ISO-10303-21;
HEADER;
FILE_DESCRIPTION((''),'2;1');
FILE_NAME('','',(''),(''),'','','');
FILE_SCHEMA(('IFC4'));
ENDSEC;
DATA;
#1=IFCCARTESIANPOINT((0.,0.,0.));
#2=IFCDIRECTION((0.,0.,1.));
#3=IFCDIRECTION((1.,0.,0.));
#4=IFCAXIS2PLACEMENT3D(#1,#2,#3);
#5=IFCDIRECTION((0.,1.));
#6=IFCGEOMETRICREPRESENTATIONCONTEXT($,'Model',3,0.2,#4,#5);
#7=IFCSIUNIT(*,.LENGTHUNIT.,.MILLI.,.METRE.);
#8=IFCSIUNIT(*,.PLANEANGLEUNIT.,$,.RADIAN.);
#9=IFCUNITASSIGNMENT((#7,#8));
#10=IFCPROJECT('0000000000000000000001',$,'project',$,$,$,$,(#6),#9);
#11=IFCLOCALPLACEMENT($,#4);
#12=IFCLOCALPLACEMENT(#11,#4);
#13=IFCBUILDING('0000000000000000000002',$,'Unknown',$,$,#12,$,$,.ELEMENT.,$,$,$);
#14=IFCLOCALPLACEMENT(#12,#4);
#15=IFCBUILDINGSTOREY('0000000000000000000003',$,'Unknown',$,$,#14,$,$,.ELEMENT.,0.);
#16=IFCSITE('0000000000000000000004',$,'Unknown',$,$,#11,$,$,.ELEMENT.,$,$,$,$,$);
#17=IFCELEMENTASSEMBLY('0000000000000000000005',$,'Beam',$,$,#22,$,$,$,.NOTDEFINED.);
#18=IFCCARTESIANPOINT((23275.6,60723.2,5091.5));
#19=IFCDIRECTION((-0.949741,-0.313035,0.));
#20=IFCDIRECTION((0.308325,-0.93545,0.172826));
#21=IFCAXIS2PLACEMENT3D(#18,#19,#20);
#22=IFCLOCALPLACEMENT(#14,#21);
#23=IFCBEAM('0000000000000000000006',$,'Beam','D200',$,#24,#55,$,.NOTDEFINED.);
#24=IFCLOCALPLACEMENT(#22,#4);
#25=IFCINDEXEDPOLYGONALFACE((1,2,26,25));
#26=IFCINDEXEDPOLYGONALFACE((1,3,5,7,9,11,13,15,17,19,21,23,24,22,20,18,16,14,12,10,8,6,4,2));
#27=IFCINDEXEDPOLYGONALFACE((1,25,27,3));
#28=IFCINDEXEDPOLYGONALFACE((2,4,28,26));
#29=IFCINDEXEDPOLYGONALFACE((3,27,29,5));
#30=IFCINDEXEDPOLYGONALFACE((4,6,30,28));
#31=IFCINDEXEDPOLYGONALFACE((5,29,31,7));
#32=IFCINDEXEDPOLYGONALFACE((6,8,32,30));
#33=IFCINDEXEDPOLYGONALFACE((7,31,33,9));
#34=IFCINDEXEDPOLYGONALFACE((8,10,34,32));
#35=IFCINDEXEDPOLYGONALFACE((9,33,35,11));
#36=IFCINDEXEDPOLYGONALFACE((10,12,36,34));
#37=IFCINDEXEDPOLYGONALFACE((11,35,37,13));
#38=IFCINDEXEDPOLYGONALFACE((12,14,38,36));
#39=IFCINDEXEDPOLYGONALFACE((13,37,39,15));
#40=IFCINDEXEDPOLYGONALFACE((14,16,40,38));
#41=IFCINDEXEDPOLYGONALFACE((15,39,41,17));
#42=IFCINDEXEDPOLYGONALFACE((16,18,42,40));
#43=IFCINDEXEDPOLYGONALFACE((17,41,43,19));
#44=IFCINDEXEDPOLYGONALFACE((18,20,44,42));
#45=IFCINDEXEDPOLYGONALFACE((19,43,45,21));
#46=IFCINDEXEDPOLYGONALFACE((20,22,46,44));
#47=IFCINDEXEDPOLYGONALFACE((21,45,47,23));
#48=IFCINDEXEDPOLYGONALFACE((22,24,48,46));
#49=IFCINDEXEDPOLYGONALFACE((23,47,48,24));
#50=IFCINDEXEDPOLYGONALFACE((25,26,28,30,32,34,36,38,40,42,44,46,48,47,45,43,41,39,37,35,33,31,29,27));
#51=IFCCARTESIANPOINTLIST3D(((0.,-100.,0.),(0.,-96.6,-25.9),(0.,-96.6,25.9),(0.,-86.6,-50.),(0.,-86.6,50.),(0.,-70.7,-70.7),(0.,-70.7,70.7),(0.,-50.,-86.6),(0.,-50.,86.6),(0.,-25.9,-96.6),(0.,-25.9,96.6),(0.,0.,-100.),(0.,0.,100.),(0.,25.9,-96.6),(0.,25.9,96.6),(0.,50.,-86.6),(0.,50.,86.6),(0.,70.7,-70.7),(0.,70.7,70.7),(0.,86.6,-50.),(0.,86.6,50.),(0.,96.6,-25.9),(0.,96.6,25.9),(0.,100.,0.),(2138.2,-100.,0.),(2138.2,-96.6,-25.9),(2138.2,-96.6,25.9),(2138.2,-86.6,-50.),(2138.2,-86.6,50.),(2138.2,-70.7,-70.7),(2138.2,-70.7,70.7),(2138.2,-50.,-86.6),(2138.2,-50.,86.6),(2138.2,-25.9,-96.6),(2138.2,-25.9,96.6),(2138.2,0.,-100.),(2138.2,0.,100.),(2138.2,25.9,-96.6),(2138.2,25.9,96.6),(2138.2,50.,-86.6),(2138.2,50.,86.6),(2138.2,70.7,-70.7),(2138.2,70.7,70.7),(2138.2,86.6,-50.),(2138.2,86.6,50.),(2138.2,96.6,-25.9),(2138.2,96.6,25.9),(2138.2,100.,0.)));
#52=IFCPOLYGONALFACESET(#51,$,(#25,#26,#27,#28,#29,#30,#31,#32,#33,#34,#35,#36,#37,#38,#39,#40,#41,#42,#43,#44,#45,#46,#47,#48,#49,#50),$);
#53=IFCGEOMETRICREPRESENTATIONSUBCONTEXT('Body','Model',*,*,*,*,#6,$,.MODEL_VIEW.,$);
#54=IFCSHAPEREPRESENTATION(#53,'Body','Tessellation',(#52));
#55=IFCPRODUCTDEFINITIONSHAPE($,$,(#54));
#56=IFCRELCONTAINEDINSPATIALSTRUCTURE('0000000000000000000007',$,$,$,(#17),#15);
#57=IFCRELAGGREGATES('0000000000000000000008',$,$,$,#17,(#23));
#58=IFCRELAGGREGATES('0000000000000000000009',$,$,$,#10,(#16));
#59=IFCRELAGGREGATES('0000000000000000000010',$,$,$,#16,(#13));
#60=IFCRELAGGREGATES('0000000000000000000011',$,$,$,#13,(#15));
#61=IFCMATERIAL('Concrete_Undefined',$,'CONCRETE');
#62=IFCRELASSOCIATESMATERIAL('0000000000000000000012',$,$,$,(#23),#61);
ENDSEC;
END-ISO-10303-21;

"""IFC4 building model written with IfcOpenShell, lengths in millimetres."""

from ifc_helpers import new_model, si_unit, direction, frame, origin_with_axes, place, context, subcontext, project, spatial, line, indexed_curve, outline, extrude, material, element, aggregate, save


model = new_model("IFC4")

# Units and contexts
model_context = context("Model", 3, precision=0.2, world=origin_with_axes(), true_north=direction((0.0, 1.0)))
body_context = subcontext(model_context, "Body", "Model", "MODEL_VIEW")
ifc_project = project(units=[si_unit("LENGTHUNIT", "METRE", prefix="MILLI"), si_unit("PLANEANGLEUNIT", "RADIAN")], contexts=[model_context])

# Site, building, storey
site_placement = place(None, origin_with_axes())
site = spatial("IfcSite", under=ifc_project, at=site_placement, Name="Unknown", CompositionType="ELEMENT")
building_placement = place(site_placement, origin_with_axes())
building = spatial("IfcBuilding", under=site, at=building_placement, Name="Unknown", CompositionType="ELEMENT")
storey_placement = place(building_placement, origin_with_axes())
storey = spatial("IfcBuildingStorey", under=building, at=storey_placement, Name="Unknown", CompositionType="ELEMENT", Elevation=0.0)

# Element assembly, beam
ifc_material = material(Name="Concrete_Undefined", Category="CONCRETE")
assembly_1_placement = place(storey_placement, frame((23275.6, 60723.2, 5091.5), z_axis=(-0.949741, -0.313035, 0.0), x_axis=(0.308325, -0.93545, 0.172826)))
assembly_1 = element("IfcElementAssembly", 1, at=assembly_1_placement, inside=storey, Name="Beam", PredefinedType="NOTDEFINED")
beam_1_placement = place(assembly_1_placement, origin_with_axes())
beam_1 = element("IfcBeam", 2, at=beam_1_placement, material=ifc_material, Name="Beam", Description="D200", PredefinedType="NOTDEFINED", context=body_context, shape_type="SolidModel", body=[
    extrude(outline(indexed_curve([(100.0, 0.0), (96.6, 25.9), (86.6, 50.0), (70.7, 70.7), (50.0, 86.6), (25.9, 96.6), (0.0, 100.0), (-25.9, 96.6), (-50.0, 86.6), (-70.7, 70.7), (-86.6, 50.0), (-96.6, 25.9), (-100.0, 0.0), (-96.6, -25.9), (-86.6, -50.0), (-70.7, -70.7), (-50.0, -86.6), (-25.9, -96.6), (0.0, -100.0), (25.9, -96.6), (50.0, -86.6), (70.7, -70.7), (86.6, -50.0), (96.6, -25.9)], segments=[line(1, 2, 3, 4, 5, 6, 7, 8, 9, 10, 11, 12, 13, 14, 15, 16, 17, 18, 19, 20, 21, 22, 23, 24, 1)])), frame((0.0, 0.0, 0.0), z_axis=(-1.0, 0.0, 0.0), x_axis=(0.0, 0.0, 1.0)), (0.0, 0.0, -1.0), 2138.2),
])
aggregate(assembly_1, [beam_1])

save(model, "model.ifc")
